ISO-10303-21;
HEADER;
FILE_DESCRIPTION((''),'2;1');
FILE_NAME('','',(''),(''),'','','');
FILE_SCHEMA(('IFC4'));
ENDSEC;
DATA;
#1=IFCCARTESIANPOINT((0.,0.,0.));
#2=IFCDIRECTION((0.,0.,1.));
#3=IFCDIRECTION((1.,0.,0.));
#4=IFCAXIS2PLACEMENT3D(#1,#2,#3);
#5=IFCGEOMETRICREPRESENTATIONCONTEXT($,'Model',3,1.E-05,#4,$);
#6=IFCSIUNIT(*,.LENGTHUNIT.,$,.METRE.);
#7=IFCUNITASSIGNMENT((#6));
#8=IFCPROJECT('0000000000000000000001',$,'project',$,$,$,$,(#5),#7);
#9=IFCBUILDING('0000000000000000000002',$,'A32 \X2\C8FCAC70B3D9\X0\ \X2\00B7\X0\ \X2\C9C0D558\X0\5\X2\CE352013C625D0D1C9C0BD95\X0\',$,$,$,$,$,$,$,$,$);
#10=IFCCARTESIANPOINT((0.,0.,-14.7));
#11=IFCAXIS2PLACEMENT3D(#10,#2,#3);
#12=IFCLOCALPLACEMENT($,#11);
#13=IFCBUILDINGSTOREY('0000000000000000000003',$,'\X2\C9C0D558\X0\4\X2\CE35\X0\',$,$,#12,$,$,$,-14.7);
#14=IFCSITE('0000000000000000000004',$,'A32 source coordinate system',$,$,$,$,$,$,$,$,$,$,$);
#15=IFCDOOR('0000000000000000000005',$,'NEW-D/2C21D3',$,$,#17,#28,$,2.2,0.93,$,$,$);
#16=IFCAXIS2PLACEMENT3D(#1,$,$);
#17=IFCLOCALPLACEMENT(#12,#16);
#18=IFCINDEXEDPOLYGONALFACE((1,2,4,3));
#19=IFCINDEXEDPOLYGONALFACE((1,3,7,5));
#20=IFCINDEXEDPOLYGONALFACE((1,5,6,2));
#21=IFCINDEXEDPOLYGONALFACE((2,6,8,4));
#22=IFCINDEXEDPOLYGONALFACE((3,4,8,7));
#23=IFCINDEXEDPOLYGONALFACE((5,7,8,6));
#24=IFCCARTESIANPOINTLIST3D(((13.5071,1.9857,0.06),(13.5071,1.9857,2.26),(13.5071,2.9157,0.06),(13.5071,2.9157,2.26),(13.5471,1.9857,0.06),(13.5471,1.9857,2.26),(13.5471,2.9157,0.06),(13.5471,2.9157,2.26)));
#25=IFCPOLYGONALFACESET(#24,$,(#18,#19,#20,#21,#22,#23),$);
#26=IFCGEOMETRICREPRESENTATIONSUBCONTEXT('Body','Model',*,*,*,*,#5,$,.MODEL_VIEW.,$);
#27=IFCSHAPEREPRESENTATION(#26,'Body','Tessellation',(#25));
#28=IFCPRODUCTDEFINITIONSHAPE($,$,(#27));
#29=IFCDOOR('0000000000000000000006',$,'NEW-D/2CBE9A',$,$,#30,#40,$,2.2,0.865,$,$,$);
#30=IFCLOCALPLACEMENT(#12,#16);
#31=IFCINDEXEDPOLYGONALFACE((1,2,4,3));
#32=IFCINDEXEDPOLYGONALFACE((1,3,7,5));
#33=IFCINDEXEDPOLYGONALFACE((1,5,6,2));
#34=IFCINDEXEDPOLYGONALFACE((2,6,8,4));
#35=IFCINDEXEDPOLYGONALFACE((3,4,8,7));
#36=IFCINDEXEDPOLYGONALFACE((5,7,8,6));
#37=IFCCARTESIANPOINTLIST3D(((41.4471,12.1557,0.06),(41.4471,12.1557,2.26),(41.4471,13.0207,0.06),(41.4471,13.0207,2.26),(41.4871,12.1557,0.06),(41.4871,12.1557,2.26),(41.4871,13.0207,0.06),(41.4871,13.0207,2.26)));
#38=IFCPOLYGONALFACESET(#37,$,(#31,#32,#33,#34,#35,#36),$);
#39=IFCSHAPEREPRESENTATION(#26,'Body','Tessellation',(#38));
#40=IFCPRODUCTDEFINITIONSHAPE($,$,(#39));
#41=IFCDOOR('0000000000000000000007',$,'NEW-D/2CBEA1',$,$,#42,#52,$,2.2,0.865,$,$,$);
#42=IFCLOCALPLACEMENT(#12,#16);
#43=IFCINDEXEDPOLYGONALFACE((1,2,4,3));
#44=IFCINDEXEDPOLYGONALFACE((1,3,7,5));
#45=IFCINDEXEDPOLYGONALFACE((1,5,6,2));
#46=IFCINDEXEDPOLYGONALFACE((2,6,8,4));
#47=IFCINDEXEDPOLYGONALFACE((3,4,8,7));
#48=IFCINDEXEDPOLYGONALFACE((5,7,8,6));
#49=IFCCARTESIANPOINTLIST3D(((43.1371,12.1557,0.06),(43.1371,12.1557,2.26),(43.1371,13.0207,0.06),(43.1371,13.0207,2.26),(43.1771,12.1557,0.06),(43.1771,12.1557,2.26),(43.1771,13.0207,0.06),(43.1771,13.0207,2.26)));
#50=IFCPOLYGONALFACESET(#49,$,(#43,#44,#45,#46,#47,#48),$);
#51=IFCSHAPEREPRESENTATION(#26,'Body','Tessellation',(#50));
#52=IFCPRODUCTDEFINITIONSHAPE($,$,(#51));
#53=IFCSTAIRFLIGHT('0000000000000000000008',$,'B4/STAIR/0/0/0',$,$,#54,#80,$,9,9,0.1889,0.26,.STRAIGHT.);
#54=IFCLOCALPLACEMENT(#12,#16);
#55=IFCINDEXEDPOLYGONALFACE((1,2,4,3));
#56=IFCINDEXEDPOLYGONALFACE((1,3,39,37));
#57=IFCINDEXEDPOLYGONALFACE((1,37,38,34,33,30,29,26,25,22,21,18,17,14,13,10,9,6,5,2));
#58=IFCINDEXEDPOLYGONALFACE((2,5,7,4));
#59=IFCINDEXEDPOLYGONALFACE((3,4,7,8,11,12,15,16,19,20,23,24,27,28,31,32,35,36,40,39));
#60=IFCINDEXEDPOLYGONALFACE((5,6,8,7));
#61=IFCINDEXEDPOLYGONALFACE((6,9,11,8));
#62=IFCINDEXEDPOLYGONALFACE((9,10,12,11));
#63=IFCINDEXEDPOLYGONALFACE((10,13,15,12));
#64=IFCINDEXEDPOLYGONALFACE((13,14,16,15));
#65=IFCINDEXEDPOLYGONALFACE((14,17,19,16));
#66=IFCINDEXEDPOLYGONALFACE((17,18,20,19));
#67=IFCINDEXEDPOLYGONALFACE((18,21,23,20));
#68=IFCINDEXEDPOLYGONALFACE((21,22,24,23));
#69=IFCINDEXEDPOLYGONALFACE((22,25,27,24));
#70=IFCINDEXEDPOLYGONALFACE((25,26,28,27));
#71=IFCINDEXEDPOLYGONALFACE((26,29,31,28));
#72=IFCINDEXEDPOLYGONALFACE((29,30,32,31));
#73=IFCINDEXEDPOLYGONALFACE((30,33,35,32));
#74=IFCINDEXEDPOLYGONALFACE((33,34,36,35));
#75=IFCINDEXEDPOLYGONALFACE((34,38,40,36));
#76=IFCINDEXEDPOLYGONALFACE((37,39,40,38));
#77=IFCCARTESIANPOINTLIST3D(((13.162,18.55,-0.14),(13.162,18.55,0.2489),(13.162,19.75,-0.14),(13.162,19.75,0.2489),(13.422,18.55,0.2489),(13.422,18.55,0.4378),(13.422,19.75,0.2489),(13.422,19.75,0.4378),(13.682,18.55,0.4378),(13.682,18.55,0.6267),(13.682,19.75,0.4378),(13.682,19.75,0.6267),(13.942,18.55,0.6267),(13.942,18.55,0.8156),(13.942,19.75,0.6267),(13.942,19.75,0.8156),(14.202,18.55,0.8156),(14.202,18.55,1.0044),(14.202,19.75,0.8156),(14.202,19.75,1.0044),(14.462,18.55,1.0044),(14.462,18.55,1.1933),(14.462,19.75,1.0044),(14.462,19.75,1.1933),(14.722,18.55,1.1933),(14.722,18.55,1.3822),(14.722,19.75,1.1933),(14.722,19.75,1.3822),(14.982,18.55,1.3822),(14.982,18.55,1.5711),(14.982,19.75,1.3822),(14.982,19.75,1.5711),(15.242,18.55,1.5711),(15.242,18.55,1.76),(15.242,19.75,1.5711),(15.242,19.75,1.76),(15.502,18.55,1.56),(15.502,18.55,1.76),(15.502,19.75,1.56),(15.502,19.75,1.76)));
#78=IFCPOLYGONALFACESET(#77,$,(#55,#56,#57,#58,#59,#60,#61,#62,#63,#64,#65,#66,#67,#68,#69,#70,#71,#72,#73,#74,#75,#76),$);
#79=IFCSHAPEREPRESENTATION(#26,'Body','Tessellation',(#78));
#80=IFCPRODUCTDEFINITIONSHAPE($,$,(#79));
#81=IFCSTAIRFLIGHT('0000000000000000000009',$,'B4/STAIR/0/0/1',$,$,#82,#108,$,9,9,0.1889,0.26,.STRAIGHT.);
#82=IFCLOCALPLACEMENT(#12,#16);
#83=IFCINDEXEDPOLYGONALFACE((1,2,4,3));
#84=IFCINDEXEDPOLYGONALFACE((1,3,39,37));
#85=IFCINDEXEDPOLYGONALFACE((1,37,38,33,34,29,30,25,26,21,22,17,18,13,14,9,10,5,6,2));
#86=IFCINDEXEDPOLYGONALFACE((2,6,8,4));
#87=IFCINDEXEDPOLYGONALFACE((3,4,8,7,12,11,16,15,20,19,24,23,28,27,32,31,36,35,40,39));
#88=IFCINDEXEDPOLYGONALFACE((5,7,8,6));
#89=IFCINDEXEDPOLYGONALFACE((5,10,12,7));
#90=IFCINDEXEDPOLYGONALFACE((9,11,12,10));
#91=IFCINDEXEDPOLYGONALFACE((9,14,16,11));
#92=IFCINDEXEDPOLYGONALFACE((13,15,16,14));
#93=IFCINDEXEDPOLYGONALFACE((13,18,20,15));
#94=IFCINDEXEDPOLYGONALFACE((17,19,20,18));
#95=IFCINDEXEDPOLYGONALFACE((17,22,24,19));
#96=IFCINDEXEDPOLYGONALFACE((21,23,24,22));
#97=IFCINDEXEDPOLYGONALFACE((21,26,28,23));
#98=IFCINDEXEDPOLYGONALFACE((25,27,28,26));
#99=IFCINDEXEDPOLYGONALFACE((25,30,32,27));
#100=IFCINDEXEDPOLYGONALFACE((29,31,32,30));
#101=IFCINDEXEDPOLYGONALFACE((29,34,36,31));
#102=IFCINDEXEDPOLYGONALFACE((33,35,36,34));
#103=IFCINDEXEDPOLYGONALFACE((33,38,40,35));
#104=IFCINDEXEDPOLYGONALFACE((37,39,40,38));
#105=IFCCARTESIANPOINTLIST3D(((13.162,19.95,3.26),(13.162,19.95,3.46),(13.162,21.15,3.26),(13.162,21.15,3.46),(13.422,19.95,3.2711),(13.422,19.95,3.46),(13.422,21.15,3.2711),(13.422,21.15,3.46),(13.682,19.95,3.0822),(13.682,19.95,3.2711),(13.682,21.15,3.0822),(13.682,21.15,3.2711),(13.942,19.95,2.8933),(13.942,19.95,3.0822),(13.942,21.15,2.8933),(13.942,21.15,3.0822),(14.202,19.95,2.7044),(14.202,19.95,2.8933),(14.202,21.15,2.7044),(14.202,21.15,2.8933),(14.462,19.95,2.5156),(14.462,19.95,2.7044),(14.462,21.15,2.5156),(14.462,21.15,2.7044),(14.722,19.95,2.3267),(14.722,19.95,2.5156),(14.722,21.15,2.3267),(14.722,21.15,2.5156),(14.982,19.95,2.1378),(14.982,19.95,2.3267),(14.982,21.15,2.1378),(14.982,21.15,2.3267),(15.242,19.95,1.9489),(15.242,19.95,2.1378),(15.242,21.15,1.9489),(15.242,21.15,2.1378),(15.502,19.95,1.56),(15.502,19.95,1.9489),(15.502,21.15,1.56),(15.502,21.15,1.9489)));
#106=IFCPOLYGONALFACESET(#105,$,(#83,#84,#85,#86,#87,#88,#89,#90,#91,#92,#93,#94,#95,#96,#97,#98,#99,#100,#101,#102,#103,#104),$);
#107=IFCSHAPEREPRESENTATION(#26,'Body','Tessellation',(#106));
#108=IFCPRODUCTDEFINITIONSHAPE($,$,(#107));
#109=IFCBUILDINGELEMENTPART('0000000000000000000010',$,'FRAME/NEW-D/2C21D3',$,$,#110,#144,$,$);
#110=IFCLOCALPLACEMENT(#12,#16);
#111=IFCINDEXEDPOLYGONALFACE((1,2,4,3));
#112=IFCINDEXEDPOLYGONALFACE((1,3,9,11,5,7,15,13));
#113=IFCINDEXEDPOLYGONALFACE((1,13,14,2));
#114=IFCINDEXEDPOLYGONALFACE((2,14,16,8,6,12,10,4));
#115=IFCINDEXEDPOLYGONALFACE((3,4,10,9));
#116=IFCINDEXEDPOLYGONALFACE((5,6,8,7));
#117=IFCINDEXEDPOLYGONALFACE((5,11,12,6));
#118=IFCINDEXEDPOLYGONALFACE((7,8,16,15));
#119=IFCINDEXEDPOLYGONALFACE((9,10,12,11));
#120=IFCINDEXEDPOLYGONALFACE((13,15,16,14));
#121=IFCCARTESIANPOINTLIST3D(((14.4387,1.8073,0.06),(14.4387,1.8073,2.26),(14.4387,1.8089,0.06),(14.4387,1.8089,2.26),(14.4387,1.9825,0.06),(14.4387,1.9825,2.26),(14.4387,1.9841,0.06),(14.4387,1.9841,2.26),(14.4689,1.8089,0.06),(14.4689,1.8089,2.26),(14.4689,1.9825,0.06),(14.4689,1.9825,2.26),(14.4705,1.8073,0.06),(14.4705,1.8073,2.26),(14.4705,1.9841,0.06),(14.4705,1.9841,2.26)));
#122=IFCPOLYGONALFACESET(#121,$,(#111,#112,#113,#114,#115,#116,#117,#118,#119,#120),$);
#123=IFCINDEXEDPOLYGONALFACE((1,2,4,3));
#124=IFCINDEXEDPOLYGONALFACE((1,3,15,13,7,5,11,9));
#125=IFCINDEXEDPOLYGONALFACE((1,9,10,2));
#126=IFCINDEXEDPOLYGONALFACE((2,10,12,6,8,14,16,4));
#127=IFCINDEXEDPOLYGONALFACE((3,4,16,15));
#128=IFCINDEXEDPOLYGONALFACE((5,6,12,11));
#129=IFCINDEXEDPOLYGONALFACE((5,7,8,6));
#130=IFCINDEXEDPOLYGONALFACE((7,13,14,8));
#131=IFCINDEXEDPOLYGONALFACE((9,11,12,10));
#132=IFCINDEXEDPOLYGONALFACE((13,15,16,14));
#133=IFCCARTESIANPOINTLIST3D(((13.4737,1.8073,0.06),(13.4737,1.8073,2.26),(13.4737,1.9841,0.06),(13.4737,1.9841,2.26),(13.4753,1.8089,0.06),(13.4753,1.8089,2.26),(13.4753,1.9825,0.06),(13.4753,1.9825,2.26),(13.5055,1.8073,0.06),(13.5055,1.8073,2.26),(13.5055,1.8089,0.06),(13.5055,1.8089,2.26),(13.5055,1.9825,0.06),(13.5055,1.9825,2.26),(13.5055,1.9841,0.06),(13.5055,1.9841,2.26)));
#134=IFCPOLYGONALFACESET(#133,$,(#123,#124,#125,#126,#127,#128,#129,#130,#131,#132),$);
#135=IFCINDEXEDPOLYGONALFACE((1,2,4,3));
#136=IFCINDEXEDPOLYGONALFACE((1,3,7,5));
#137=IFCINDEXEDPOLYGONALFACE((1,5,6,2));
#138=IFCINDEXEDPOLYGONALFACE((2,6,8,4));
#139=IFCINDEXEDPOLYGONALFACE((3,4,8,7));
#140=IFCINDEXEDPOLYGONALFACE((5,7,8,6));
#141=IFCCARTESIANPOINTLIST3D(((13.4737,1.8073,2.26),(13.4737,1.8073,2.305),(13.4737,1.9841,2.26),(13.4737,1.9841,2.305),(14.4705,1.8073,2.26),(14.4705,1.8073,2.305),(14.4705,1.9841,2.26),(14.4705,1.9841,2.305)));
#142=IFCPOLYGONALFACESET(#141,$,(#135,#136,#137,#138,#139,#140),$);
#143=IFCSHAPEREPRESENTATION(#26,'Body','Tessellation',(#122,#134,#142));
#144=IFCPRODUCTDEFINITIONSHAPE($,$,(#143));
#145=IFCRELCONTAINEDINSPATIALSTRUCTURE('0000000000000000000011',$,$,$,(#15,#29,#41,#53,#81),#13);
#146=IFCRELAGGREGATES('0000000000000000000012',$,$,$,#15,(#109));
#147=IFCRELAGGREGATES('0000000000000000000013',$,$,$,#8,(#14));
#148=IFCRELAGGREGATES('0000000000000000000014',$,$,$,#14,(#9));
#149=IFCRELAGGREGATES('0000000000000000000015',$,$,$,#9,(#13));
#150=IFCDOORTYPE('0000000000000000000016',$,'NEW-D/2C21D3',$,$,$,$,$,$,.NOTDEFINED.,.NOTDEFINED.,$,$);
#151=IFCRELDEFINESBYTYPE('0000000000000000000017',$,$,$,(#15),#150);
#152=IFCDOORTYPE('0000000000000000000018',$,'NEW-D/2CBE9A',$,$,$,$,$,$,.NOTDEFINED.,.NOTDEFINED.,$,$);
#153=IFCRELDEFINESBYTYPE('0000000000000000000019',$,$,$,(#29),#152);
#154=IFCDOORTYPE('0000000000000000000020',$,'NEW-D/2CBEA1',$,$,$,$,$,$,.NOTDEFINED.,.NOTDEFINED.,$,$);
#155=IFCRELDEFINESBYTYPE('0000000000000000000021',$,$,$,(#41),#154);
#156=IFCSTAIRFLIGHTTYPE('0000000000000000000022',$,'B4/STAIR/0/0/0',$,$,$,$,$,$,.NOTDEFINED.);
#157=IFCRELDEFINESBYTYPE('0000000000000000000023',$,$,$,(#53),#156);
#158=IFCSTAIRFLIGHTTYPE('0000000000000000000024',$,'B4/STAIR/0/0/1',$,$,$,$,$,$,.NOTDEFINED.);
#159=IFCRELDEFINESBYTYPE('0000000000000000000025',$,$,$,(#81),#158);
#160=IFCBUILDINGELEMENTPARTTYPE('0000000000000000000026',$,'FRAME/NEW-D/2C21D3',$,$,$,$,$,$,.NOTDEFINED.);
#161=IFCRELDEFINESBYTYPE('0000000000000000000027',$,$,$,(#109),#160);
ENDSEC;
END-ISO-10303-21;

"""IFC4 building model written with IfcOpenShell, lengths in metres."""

from ifc_helpers import new_model, si_unit, frame, origin, origin_with_axes, place, context, subcontext, project, spatial, polyline, outline, extrude, source, transform, mapped, type_object, type_shapes, element, aggregate, save


model = new_model("IFC4")

# Units and contexts
model_context = context("Model", 3, precision=1e-05, world=origin_with_axes())
body_context = subcontext(model_context, "Body", "Model", "MODEL_VIEW")
ifc_project = project(units=[si_unit("LENGTHUNIT", "METRE")], contexts=[model_context])

# Site, building, storey
site = spatial("IfcSite", under=ifc_project, Name="A32 source coordinate system")
building = spatial("IfcBuilding", under=site, Name="A32 주거동 · 지하5층–옥탑지붕")
storey_placement = place(None, frame((0.0, 0.0, -14.7), z_axis=(0.0, 0.0, 1.0), x_axis=(1.0, 0.0, 0.0)))
storey = spatial("IfcBuildingStorey", under=building, at=storey_placement, Name="지하4층", Elevation=-14.7)

# Door
door_type_1 = type_object("IfcDoorType", Name="NEW-D/2C21D3", OperationType="NOTDEFINED", PredefinedType="NOTDEFINED")
shared_shape_1 = source(origin(), body_context, "Body", "SweptSolid", [
    extrude(outline(polyline([(13.5471, 2.9157), (13.5471, 1.9857), (13.5071, 1.9857), (13.5071, 2.9157), (13.5471, 2.9157)])), frame((0.0, 0.0, 0.06)), (0.0, 0.0, 1.0), 2.2),
])
type_shapes(door_type_1, [shared_shape_1])
door_1_placement = place(storey_placement, origin_with_axes())
door_1 = element("IfcDoor", 1, at=door_1_placement, inside=storey, type_object=door_type_1, Name="NEW-D/2C21D3", OverallHeight=2.2, OverallWidth=0.93, context=body_context, shape_type="MappedRepresentation", body=[
    mapped(shared_shape_1, transform((0.0, 0.0, 0.0), scale=1.0)),
])

# Doors
door_type_2 = type_object("IfcDoorType", Name="NEW-D/2CBE9A", OperationType="NOTDEFINED", PredefinedType="NOTDEFINED")
shared_shape_2 = source(origin(), body_context, "Body", "SweptSolid", [
    extrude(outline(polyline([(41.4871, 12.1557), (41.4471, 12.1557), (41.4471, 13.0207), (41.4871, 13.0207), (41.4871, 12.1557)])), frame((0.0, 0.0, 0.06)), (0.0, 0.0, 1.0), 2.2),
])
type_shapes(door_type_2, [shared_shape_2])
door_2_placement = place(storey_placement, origin_with_axes())
element("IfcDoor", 2, at=door_2_placement, inside=storey, type_object=door_type_2, Name="NEW-D/2CBE9A", OverallHeight=2.2, OverallWidth=0.865, context=body_context, shape_type="MappedRepresentation", body=[
    mapped(shared_shape_2, transform((0.0, 0.0, 0.0), scale=1.0)),
])
door_type_3 = type_object("IfcDoorType", Name="NEW-D/2CBEA1", OperationType="NOTDEFINED", PredefinedType="NOTDEFINED")
shared_shape_3 = source(origin(), body_context, "Body", "SweptSolid", [
    extrude(outline(polyline([(43.1771, 13.0207), (43.1771, 12.1557), (43.1371, 12.1557), (43.1371, 13.0207), (43.1771, 13.0207)])), frame((0.0, 0.0, 0.06)), (0.0, 0.0, 1.0), 2.2),
])
type_shapes(door_type_3, [shared_shape_3])
door_3_placement = place(storey_placement, origin_with_axes())
element("IfcDoor", 3, at=door_3_placement, inside=storey, type_object=door_type_3, Name="NEW-D/2CBEA1", OverallHeight=2.2, OverallWidth=0.865, context=body_context, shape_type="MappedRepresentation", body=[
    mapped(shared_shape_3, transform((0.0, 0.0, 0.0), scale=1.0)),
])

# Stair flights
stair_flight_type_1 = type_object("IfcStairFlightType", Name="B4/STAIR/0/0/0", PredefinedType="NOTDEFINED")
shared_shape_4 = source(origin(), body_context, "Body", "SweptSolid", [
    extrude(outline(polyline([(0.0, -0.14), (2.34, 1.56), (2.34, 1.76), (2.08, 1.76), (2.08, 1.5711), (1.82, 1.5711), (1.82, 1.3822), (1.56, 1.3822), (1.56, 1.1933), (1.3, 1.1933), (1.3, 1.0044), (1.04, 1.0044), (1.04, 0.8156), (0.78, 0.8156), (0.78, 0.6267), (0.52, 0.6267), (0.52, 0.4378), (0.26, 0.4378), (0.26, 0.2489), (0.0, 0.2489), (0.0, -0.14)])), frame((13.162, 19.75, 0.0), z_axis=(0.0, -1.0, 0.0), x_axis=(1.0, 0.0, 0.0)), (0.0, 0.0, 1.0), 1.2),
])
type_shapes(stair_flight_type_1, [shared_shape_4])
stair_flight_1_placement = place(storey_placement, origin_with_axes())
element("IfcStairFlight", 4, at=stair_flight_1_placement, inside=storey, type_object=stair_flight_type_1, Name="B4/STAIR/0/0/0", NumberOfRisers=9, NumberOfTreads=9, PredefinedType="STRAIGHT", RiserHeight=0.1889, TreadLength=0.26, context=body_context, shape_type="MappedRepresentation", body=[
    mapped(shared_shape_4, transform((0.0, 0.0, 0.0), scale=1.0)),
])
stair_flight_type_2 = type_object("IfcStairFlightType", Name="B4/STAIR/0/0/1", PredefinedType="NOTDEFINED")
shared_shape_5 = source(origin(), body_context, "Body", "SweptSolid", [
    extrude(outline(polyline([(0.0, 1.56), (2.34, 3.26), (2.34, 3.46), (2.08, 3.46), (2.08, 3.2711), (1.82, 3.2711), (1.82, 3.0822), (1.56, 3.0822), (1.56, 2.8933), (1.3, 2.8933), (1.3, 2.7044), (1.04, 2.7044), (1.04, 2.5156), (0.78, 2.5156), (0.78, 2.3267), (0.52, 2.3267), (0.52, 2.1378), (0.26, 2.1378), (0.26, 1.9489), (0.0, 1.9489), (0.0, 1.56)])), frame((15.502, 19.95, 0.0), z_axis=(0.0, 1.0, 0.0), x_axis=(-1.0, 0.0, 0.0)), (0.0, 0.0, 1.0), 1.2),
])
type_shapes(stair_flight_type_2, [shared_shape_5])
stair_flight_2_placement = place(storey_placement, origin_with_axes())
element("IfcStairFlight", 5, at=stair_flight_2_placement, inside=storey, type_object=stair_flight_type_2, Name="B4/STAIR/0/0/1", NumberOfRisers=9, NumberOfTreads=9, PredefinedType="STRAIGHT", RiserHeight=0.1889, TreadLength=0.26, context=body_context, shape_type="MappedRepresentation", body=[
    mapped(shared_shape_5, transform((0.0, 0.0, 0.0), scale=1.0)),
])

# Building element part
building_element_part_type_1 = type_object("IfcBuildingElementPartType", Name="FRAME/NEW-D/2C21D3", PredefinedType="NOTDEFINED")
shared_shape_6 = source(origin(), body_context, "Body", "SweptSolid", [
    extrude(outline(polyline([(14.4705, 1.8073), (14.4387, 1.8073), (14.4387, 1.8089), (14.4689, 1.8089), (14.4689, 1.9825), (14.4387, 1.9825), (14.4387, 1.9841), (14.4705, 1.9841), (14.4705, 1.8073)])), frame((0.0, 0.0, 0.06)), (0.0, 0.0, 1.0), 2.2),
    extrude(outline(polyline([(13.4753, 1.9825), (13.4753, 1.8089), (13.5055, 1.8089), (13.5055, 1.8073), (13.4737, 1.8073), (13.4737, 1.9841), (13.5055, 1.9841), (13.5055, 1.9825), (13.4753, 1.9825)])), frame((0.0, 0.0, 0.06)), (0.0, 0.0, 1.0), 2.2),
    extrude(outline(polyline([(14.4705, 1.8073), (14.4705, 1.9841), (13.4737, 1.9841), (13.4737, 1.8073), (14.4705, 1.8073)])), frame((0.0, 0.0, 2.26)), (0.0, 0.0, 1.0), 0.045),
])
type_shapes(building_element_part_type_1, [shared_shape_6])
building_element_part_1_placement = place(door_1_placement, origin_with_axes())
building_element_part_1 = element("IfcBuildingElementPart", 6, at=building_element_part_1_placement, type_object=building_element_part_type_1, Name="FRAME/NEW-D/2C21D3", context=body_context, shape_type="MappedRepresentation", body=[
    mapped(shared_shape_6, transform((0.0, 0.0, 0.0), scale=1.0)),
])
aggregate(door_1, [building_element_part_1])

save(model, "model.ifc")
